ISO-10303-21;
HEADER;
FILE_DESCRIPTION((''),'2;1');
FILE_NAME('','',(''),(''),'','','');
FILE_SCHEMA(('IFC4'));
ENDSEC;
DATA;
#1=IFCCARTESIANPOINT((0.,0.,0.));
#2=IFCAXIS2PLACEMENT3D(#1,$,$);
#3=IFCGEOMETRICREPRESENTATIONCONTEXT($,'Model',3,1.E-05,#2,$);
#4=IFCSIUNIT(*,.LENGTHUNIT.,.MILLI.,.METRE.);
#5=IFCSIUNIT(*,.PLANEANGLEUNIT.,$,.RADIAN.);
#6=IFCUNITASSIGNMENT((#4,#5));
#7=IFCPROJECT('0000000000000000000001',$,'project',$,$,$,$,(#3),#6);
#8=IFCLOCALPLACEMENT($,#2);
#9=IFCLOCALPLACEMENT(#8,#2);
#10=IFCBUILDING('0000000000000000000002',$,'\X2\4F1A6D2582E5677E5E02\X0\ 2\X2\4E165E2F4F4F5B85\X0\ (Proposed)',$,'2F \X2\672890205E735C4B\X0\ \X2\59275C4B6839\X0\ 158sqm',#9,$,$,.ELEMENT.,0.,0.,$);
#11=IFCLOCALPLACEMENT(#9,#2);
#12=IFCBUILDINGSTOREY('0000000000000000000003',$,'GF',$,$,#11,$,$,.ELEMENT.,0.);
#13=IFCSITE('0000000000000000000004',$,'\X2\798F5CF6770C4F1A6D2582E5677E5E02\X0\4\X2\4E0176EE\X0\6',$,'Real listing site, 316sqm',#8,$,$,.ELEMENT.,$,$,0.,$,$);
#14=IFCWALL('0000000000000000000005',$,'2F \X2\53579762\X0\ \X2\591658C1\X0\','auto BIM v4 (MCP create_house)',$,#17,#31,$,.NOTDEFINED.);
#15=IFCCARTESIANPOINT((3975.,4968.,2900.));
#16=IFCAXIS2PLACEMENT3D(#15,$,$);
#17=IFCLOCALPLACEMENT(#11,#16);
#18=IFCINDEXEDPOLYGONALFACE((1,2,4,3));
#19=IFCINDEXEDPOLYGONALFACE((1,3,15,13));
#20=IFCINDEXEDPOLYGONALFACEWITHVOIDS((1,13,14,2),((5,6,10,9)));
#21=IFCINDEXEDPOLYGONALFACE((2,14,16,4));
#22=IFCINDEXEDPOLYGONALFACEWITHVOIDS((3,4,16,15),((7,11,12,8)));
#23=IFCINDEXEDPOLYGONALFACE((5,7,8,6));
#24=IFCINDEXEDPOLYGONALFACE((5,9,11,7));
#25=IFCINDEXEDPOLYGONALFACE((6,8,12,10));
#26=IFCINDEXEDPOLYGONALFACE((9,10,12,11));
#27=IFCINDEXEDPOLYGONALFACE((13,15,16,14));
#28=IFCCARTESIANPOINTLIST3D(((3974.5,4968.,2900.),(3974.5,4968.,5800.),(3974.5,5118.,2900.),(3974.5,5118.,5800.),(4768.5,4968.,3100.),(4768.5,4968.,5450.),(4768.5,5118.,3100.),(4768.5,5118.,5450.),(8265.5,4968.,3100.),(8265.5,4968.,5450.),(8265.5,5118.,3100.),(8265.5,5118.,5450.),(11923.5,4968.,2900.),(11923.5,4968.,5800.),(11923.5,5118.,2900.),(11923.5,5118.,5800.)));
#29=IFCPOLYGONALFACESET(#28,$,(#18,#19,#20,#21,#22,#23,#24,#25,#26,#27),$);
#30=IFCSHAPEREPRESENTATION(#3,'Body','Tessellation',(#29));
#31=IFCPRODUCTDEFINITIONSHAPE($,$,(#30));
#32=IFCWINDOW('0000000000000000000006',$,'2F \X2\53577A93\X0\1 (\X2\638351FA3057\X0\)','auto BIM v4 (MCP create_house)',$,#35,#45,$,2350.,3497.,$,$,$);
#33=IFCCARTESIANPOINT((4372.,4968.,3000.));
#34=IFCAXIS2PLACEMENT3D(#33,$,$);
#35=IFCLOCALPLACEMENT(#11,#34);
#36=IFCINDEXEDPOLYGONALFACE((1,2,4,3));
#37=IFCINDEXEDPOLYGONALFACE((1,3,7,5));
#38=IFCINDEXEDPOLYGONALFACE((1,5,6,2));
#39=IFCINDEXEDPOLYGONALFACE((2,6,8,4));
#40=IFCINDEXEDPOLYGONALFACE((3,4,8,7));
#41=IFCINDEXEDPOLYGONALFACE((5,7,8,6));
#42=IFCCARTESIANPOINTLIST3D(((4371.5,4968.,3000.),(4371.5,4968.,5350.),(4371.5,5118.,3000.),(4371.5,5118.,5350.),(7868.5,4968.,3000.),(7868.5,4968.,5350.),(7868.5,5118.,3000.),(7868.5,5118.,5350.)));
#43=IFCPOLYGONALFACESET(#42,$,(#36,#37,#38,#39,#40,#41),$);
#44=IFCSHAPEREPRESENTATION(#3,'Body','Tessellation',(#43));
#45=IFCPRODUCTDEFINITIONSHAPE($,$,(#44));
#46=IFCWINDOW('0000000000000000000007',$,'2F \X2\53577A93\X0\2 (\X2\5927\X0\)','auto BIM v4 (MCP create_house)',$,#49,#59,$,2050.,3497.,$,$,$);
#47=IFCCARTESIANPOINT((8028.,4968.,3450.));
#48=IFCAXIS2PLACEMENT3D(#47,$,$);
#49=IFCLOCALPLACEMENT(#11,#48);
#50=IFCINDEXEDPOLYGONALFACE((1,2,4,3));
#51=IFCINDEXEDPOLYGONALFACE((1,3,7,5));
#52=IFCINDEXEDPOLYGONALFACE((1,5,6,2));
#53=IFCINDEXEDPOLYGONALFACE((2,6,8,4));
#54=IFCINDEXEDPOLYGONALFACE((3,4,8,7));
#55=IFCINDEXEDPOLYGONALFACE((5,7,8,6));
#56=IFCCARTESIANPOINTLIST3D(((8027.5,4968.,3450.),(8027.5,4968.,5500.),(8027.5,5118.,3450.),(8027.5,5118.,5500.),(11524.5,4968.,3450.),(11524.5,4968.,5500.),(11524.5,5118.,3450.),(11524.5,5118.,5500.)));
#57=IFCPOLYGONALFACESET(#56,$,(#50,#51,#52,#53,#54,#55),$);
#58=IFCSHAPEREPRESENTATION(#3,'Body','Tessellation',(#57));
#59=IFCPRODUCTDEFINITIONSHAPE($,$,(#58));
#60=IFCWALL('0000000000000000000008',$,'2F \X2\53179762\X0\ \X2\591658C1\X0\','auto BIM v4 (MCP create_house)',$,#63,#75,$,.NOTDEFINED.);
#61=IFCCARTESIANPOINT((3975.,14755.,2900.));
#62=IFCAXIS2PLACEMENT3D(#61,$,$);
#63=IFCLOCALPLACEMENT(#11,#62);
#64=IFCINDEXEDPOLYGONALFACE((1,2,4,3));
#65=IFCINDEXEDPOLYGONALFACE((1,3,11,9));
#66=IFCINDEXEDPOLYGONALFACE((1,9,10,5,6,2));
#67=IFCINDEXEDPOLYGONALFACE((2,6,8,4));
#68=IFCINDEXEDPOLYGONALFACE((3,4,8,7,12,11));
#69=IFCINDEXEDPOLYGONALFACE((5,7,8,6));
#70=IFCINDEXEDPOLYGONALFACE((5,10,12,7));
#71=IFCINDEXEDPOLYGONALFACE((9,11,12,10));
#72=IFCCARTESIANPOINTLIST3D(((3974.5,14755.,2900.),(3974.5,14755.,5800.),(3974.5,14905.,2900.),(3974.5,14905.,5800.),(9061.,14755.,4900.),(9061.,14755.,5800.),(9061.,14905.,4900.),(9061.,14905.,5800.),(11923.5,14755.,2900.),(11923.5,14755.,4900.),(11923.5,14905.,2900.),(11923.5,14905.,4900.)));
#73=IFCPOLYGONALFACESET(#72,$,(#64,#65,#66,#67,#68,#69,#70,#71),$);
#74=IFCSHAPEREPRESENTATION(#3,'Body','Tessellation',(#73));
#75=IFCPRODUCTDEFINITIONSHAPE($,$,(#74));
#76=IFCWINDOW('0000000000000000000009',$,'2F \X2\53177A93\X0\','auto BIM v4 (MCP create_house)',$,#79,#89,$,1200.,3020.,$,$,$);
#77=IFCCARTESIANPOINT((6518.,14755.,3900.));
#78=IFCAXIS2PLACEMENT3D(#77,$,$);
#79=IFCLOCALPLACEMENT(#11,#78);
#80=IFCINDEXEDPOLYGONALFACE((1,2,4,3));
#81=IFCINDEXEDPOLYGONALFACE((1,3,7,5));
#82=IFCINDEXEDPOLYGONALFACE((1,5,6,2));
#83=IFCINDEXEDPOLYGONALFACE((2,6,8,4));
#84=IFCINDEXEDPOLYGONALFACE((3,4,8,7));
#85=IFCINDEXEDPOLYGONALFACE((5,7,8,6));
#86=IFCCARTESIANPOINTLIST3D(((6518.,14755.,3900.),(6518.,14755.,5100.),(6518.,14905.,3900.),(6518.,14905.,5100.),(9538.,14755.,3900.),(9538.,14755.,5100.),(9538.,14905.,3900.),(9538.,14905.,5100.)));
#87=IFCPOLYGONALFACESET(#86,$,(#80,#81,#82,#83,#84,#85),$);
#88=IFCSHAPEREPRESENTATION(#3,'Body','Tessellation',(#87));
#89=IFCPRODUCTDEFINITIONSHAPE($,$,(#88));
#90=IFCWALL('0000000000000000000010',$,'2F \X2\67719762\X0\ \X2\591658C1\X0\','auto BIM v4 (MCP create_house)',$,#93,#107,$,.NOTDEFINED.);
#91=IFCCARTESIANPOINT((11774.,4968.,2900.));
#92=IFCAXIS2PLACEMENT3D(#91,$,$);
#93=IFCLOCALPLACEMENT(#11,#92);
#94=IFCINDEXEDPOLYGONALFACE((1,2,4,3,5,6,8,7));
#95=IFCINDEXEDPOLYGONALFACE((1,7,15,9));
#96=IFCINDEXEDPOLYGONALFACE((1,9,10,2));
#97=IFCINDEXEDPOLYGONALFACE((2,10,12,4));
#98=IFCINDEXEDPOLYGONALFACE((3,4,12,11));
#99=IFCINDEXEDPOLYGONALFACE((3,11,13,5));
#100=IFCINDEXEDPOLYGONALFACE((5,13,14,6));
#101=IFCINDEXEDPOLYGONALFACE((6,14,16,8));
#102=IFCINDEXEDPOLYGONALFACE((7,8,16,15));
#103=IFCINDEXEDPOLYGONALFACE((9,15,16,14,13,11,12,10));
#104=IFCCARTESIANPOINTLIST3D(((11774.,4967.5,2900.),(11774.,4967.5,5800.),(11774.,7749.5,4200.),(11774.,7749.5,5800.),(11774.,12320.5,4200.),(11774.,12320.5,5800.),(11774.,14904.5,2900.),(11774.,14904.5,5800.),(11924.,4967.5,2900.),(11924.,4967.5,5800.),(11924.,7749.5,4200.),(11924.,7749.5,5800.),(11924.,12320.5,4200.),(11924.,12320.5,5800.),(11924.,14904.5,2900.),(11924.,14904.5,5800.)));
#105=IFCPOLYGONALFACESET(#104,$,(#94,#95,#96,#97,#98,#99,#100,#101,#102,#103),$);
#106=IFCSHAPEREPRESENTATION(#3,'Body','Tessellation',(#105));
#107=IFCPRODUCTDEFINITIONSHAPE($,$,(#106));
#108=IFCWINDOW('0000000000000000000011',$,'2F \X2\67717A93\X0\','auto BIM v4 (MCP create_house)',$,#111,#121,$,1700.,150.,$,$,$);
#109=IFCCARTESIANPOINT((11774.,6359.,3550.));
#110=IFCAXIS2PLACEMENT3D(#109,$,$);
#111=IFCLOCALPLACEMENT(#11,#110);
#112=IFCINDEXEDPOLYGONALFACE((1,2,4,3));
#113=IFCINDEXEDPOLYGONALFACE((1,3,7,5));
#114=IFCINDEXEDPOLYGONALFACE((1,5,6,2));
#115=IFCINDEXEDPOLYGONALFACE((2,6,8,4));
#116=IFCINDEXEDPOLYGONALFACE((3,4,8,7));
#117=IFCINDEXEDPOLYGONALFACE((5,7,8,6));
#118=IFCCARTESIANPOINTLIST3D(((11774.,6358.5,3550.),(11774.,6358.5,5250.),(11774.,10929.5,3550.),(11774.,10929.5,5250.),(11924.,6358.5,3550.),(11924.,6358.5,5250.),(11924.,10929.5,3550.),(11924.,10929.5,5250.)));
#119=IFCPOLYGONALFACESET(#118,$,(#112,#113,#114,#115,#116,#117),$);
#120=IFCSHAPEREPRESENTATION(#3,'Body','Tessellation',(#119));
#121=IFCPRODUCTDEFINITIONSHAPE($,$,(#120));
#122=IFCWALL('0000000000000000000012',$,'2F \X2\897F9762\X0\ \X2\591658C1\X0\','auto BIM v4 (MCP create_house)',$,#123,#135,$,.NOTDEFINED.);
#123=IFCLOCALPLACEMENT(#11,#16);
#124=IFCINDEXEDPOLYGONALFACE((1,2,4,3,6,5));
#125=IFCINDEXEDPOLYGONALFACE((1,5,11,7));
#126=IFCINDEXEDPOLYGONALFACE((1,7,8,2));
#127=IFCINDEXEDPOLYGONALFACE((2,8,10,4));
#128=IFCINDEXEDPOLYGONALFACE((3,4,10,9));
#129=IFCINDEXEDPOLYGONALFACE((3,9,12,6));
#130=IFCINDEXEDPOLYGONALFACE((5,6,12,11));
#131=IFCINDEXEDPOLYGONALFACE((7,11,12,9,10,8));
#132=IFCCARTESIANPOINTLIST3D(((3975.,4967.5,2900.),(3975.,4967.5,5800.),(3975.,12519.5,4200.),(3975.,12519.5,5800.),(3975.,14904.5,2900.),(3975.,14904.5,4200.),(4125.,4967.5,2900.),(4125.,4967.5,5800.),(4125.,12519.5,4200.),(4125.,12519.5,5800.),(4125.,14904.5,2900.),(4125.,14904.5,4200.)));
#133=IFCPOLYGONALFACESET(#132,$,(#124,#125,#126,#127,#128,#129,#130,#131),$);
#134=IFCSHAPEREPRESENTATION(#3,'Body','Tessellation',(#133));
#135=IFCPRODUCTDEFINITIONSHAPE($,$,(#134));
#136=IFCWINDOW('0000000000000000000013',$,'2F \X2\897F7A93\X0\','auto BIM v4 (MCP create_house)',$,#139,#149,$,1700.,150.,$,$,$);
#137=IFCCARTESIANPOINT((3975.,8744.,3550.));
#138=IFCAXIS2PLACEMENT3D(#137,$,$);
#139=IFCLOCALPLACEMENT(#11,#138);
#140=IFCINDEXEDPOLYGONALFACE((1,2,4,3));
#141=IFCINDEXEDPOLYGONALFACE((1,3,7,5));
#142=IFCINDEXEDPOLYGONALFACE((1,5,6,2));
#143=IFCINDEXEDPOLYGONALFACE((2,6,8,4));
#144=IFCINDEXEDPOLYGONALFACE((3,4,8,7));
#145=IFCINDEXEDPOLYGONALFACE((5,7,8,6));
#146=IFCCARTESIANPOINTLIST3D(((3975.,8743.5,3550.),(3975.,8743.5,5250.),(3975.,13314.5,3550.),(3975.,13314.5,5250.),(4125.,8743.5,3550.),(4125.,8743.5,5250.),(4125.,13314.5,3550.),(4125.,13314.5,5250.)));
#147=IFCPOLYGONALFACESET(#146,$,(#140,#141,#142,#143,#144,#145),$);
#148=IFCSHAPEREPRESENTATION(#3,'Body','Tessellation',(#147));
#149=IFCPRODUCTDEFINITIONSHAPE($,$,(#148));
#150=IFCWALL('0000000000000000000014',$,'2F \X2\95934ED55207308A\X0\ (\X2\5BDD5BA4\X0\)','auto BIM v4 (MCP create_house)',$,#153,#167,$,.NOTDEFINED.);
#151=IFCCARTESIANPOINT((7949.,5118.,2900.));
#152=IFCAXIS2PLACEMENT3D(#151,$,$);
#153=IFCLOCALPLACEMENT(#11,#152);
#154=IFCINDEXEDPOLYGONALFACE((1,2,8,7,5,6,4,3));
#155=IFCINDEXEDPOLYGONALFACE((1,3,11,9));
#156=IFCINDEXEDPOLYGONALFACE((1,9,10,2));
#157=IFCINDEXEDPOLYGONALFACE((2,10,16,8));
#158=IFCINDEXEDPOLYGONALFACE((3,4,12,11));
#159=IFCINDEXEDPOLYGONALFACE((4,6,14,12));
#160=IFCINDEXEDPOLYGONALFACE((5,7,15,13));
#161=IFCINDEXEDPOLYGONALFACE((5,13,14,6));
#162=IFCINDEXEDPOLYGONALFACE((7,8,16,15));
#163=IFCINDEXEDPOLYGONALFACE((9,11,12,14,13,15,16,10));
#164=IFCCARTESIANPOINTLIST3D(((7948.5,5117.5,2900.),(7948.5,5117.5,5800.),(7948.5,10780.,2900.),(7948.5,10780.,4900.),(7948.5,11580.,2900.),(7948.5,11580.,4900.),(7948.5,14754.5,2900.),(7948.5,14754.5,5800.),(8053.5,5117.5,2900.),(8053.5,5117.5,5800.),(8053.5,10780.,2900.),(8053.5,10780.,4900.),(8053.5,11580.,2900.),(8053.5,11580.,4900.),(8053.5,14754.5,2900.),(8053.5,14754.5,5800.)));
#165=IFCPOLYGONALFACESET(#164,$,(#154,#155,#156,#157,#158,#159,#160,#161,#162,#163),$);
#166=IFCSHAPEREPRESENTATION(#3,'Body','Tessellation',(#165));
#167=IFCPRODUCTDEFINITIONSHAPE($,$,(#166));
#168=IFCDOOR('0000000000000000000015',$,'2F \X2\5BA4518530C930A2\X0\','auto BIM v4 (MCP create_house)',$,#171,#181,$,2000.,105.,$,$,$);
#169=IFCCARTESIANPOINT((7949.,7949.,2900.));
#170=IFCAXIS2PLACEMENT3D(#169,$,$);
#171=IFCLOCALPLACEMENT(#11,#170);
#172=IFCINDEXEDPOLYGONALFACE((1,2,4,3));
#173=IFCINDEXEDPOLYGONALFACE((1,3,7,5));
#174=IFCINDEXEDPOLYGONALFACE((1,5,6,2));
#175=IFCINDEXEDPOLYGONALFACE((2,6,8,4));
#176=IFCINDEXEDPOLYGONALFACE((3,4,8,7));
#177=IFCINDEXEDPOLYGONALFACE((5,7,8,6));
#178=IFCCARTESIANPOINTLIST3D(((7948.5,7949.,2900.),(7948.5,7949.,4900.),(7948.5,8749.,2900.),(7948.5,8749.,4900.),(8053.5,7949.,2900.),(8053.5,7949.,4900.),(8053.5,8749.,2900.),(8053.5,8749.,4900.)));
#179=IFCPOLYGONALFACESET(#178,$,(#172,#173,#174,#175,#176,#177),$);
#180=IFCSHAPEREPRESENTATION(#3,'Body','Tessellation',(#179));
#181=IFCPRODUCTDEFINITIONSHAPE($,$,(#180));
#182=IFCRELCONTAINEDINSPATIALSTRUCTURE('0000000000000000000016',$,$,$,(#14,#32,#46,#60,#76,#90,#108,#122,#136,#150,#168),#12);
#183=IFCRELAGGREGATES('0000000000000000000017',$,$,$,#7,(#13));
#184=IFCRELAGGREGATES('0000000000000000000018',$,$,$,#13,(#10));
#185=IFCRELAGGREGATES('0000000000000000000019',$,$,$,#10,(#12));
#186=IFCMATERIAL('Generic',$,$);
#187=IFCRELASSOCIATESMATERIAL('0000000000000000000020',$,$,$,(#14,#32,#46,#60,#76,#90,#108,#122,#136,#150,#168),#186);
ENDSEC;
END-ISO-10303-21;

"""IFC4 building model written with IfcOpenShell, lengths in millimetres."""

from ifc_helpers import new_model, si_unit, frame, frame_2d, origin, place, context, project, spatial, rectangle, extrude, material, element, fill, save


model = new_model("IFC4")

# Units and contexts
model_context = context("Model", 3, precision=1e-05, world=origin())
ifc_project = project(units=[si_unit("LENGTHUNIT", "METRE", prefix="MILLI"), si_unit("PLANEANGLEUNIT", "RADIAN")], contexts=[model_context])

# Site, building, storey
site_placement = place(None, origin())
site = spatial("IfcSite", under=ifc_project, at=site_placement, Name="福島県会津若松市4丁目6", ObjectType="Real listing site, 316sqm", CompositionType="ELEMENT", RefElevation=0.0)
building_placement = place(site_placement, origin())
building = spatial("IfcBuilding", under=site, at=building_placement, Name="会津若松市 2世帯住宅 (Proposed)", ObjectType="2F 木造平屋 大屋根 158sqm", CompositionType="ELEMENT", ElevationOfRefHeight=0.0, ElevationOfTerrain=0.0)
storey_placement = place(building_placement, origin())
storey = spatial("IfcBuildingStorey", under=building, at=storey_placement, Name="GF", CompositionType="ELEMENT", Elevation=0.0)

# Shared definitions
ifc_material = material(Name="Generic")

# Wall, openings, windows
wall_1_placement = place(storey_placement, frame((3975.0, 4968.0, 2900.0)))
wall_1 = element("IfcWall", 1, at=wall_1_placement, inside=storey, material=ifc_material, Name="2F 南面 外壁", Description="auto BIM v4 (MCP create_house)", PredefinedType="NOTDEFINED", context=model_context, shape_type="SweptSolid", body=[
    extrude(rectangle(XDim=7949.0, YDim=150.0, at=frame_2d((3974.0, 75.0))), frame((3975.0, 4968.0, 2900.0)), (0.0, 0.0, 1.0), 2900.0),
])
opening_1_placement = place(storey_placement, frame((4372.0, 4968.0, 3000.0)))
opening_1 = element("IfcOpeningElement", 2, at=opening_1_placement, cuts=wall_1, PredefinedType="NOTDEFINED", context=model_context, shape_type="SweptSolid", body=[
    extrude(rectangle(XDim=3497.0, YDim=150.0, at=frame_2d((1748.0, 75.0))), frame((4372.0, 4968.0, 3000.0)), (0.0, 0.0, 1.0), 2350.0),
])
opening_2_placement = place(storey_placement, frame((8028.0, 4968.0, 3450.0)))
opening_2 = element("IfcOpeningElement", 3, at=opening_2_placement, cuts=wall_1, PredefinedType="NOTDEFINED", context=model_context, shape_type="SweptSolid", body=[
    extrude(rectangle(XDim=3497.0, YDim=150.0, at=frame_2d((1748.0, 75.0))), frame((8028.0, 4968.0, 3450.0)), (0.0, 0.0, 1.0), 2050.0),
])
window_1_placement = place(storey_placement, frame((4372.0, 4968.0, 3000.0)))
window_1 = element("IfcWindow", 4, at=window_1_placement, inside=storey, material=ifc_material, Name="2F 南窓1 (掃出し)", Description="auto BIM v4 (MCP create_house)", OverallHeight=2350.0, OverallWidth=3497.0, context=model_context, shape_type="SweptSolid", body=[
    extrude(rectangle(XDim=3497.0, YDim=150.0, at=frame_2d((1748.0, 75.0))), frame((4372.0, 4968.0, 3000.0)), (0.0, 0.0, 1.0), 2350.0),
])
fill(opening_1, window_1)
window_2_placement = place(storey_placement, frame((8028.0, 4968.0, 3450.0)))
window_2 = element("IfcWindow", 5, at=window_2_placement, inside=storey, material=ifc_material, Name="2F 南窓2 (大)", Description="auto BIM v4 (MCP create_house)", OverallHeight=2050.0, OverallWidth=3497.0, context=model_context, shape_type="SweptSolid", body=[
    extrude(rectangle(XDim=3497.0, YDim=150.0, at=frame_2d((1748.0, 75.0))), frame((8028.0, 4968.0, 3450.0)), (0.0, 0.0, 1.0), 2050.0),
])
fill(opening_2, window_2)

# Walls, openings, windows
wall_2_placement = place(storey_placement, frame((3975.0, 14755.0, 2900.0)))
wall_2 = element("IfcWall", 6, at=wall_2_placement, inside=storey, material=ifc_material, Name="2F 北面 外壁", Description="auto BIM v4 (MCP create_house)", PredefinedType="NOTDEFINED", context=model_context, shape_type="SweptSolid", body=[
    extrude(rectangle(XDim=7949.0, YDim=150.0, at=frame_2d((3974.0, 75.0))), frame((3975.0, 14755.0, 2900.0)), (0.0, 0.0, 1.0), 2900.0),
])
opening_3_placement = place(storey_placement, frame((6518.0, 14755.0, 3900.0)))
opening_3 = element("IfcOpeningElement", 7, at=opening_3_placement, cuts=wall_2, PredefinedType="NOTDEFINED", context=model_context, shape_type="SweptSolid", body=[
    extrude(rectangle(XDim=3020.0, YDim=150.0, at=frame_2d((1510.0, 75.0))), frame((6518.0, 14755.0, 3900.0)), (0.0, 0.0, 1.0), 1200.0),
])
window_3_placement = place(storey_placement, frame((6518.0, 14755.0, 3900.0)))
window_3 = element("IfcWindow", 8, at=window_3_placement, inside=storey, material=ifc_material, Name="2F 北窓", Description="auto BIM v4 (MCP create_house)", OverallHeight=1200.0, OverallWidth=3020.0, context=model_context, shape_type="SweptSolid", body=[
    extrude(rectangle(XDim=3020.0, YDim=150.0, at=frame_2d((1510.0, 75.0))), frame((6518.0, 14755.0, 3900.0)), (0.0, 0.0, 1.0), 1200.0),
])
fill(opening_3, window_3)
wall_3_placement = place(storey_placement, frame((11774.0, 4968.0, 2900.0)))
wall_3 = element("IfcWall", 9, at=wall_3_placement, inside=storey, material=ifc_material, Name="2F 東面 外壁", Description="auto BIM v4 (MCP create_house)", PredefinedType="NOTDEFINED", context=model_context, shape_type="SweptSolid", body=[
    extrude(rectangle(XDim=150.0, YDim=9937.0, at=frame_2d((75.0, 4968.0))), frame((11774.0, 4968.0, 2900.0)), (0.0, 0.0, 1.0), 2900.0),
])
opening_4_placement = place(storey_placement, frame((11774.0, 6359.0, 3550.0)))
opening_4 = element("IfcOpeningElement", 10, at=opening_4_placement, cuts=wall_3, PredefinedType="NOTDEFINED", context=model_context, shape_type="SweptSolid", body=[
    extrude(rectangle(XDim=150.0, YDim=4571.0, at=frame_2d((75.0, 2285.0))), frame((11774.0, 6359.0, 3550.0)), (0.0, 0.0, 1.0), 1700.0),
])
window_4_placement = place(storey_placement, frame((11774.0, 6359.0, 3550.0)))
window_4 = element("IfcWindow", 11, at=window_4_placement, inside=storey, material=ifc_material, Name="2F 東窓", Description="auto BIM v4 (MCP create_house)", OverallHeight=1700.0, OverallWidth=150.0, context=model_context, shape_type="SweptSolid", body=[
    extrude(rectangle(XDim=150.0, YDim=4571.0, at=frame_2d((75.0, 2285.0))), frame((11774.0, 6359.0, 3550.0)), (0.0, 0.0, 1.0), 1700.0),
])
fill(opening_4, window_4)
wall_4_placement = place(storey_placement, frame((3975.0, 4968.0, 2900.0)))
wall_4 = element("IfcWall", 12, at=wall_4_placement, inside=storey, material=ifc_material, Name="2F 西面 外壁", Description="auto BIM v4 (MCP create_house)", PredefinedType="NOTDEFINED", context=model_context, shape_type="SweptSolid", body=[
    extrude(rectangle(XDim=150.0, YDim=9937.0, at=frame_2d((75.0, 4968.0))), frame((3975.0, 4968.0, 2900.0)), (0.0, 0.0, 1.0), 2900.0),
])
opening_5_placement = place(storey_placement, frame((3975.0, 8744.0, 3550.0)))
opening_5 = element("IfcOpeningElement", 13, at=opening_5_placement, cuts=wall_4, PredefinedType="NOTDEFINED", context=model_context, shape_type="SweptSolid", body=[
    extrude(rectangle(XDim=150.0, YDim=4571.0, at=frame_2d((75.0, 2285.0))), frame((3975.0, 8744.0, 3550.0)), (0.0, 0.0, 1.0), 1700.0),
])
window_5_placement = place(storey_placement, frame((3975.0, 8744.0, 3550.0)))
window_5 = element("IfcWindow", 14, at=window_5_placement, inside=storey, material=ifc_material, Name="2F 西窓", Description="auto BIM v4 (MCP create_house)", OverallHeight=1700.0, OverallWidth=150.0, context=model_context, shape_type="SweptSolid", body=[
    extrude(rectangle(XDim=150.0, YDim=4571.0, at=frame_2d((75.0, 2285.0))), frame((3975.0, 8744.0, 3550.0)), (0.0, 0.0, 1.0), 1700.0),
])
fill(opening_5, window_5)

# Wall, opening, door
wall_5_placement = place(storey_placement, frame((7949.0, 5118.0, 2900.0)))
wall_5 = element("IfcWall", 15, at=wall_5_placement, inside=storey, material=ifc_material, Name="2F 間仕切り (寝室)", Description="auto BIM v4 (MCP create_house)", PredefinedType="NOTDEFINED", context=model_context, shape_type="SweptSolid", body=[
    extrude(rectangle(XDim=105.0, YDim=9637.0, at=frame_2d((52.0, 4818.0))), frame((7949.0, 5118.0, 2900.0)), (0.0, 0.0, 1.0), 2900.0),
])
opening_6_placement = place(storey_placement, frame((7949.0, 7949.0, 2900.0)))
opening_6 = element("IfcOpeningElement", 16, at=opening_6_placement, cuts=wall_5, PredefinedType="NOTDEFINED", context=model_context, shape_type="SweptSolid", body=[
    extrude(rectangle(XDim=105.0, YDim=800.0, at=frame_2d((52.0, 400.0))), frame((7949.0, 7949.0, 2900.0)), (0.0, 0.0, 1.0), 2000.0),
])
door_1_placement = place(storey_placement, frame((7949.0, 7949.0, 2900.0)))
door_1 = element("IfcDoor", 17, at=door_1_placement, inside=storey, material=ifc_material, Name="2F 室内ドア", Description="auto BIM v4 (MCP create_house)", OverallHeight=2000.0, OverallWidth=105.0, context=model_context, shape_type="SweptSolid", body=[
    extrude(rectangle(XDim=105.0, YDim=800.0, at=frame_2d((52.0, 400.0))), frame((7949.0, 7949.0, 2900.0)), (0.0, 0.0, 1.0), 2000.0),
])
fill(opening_6, door_1)

save(model, "model.ifc")
